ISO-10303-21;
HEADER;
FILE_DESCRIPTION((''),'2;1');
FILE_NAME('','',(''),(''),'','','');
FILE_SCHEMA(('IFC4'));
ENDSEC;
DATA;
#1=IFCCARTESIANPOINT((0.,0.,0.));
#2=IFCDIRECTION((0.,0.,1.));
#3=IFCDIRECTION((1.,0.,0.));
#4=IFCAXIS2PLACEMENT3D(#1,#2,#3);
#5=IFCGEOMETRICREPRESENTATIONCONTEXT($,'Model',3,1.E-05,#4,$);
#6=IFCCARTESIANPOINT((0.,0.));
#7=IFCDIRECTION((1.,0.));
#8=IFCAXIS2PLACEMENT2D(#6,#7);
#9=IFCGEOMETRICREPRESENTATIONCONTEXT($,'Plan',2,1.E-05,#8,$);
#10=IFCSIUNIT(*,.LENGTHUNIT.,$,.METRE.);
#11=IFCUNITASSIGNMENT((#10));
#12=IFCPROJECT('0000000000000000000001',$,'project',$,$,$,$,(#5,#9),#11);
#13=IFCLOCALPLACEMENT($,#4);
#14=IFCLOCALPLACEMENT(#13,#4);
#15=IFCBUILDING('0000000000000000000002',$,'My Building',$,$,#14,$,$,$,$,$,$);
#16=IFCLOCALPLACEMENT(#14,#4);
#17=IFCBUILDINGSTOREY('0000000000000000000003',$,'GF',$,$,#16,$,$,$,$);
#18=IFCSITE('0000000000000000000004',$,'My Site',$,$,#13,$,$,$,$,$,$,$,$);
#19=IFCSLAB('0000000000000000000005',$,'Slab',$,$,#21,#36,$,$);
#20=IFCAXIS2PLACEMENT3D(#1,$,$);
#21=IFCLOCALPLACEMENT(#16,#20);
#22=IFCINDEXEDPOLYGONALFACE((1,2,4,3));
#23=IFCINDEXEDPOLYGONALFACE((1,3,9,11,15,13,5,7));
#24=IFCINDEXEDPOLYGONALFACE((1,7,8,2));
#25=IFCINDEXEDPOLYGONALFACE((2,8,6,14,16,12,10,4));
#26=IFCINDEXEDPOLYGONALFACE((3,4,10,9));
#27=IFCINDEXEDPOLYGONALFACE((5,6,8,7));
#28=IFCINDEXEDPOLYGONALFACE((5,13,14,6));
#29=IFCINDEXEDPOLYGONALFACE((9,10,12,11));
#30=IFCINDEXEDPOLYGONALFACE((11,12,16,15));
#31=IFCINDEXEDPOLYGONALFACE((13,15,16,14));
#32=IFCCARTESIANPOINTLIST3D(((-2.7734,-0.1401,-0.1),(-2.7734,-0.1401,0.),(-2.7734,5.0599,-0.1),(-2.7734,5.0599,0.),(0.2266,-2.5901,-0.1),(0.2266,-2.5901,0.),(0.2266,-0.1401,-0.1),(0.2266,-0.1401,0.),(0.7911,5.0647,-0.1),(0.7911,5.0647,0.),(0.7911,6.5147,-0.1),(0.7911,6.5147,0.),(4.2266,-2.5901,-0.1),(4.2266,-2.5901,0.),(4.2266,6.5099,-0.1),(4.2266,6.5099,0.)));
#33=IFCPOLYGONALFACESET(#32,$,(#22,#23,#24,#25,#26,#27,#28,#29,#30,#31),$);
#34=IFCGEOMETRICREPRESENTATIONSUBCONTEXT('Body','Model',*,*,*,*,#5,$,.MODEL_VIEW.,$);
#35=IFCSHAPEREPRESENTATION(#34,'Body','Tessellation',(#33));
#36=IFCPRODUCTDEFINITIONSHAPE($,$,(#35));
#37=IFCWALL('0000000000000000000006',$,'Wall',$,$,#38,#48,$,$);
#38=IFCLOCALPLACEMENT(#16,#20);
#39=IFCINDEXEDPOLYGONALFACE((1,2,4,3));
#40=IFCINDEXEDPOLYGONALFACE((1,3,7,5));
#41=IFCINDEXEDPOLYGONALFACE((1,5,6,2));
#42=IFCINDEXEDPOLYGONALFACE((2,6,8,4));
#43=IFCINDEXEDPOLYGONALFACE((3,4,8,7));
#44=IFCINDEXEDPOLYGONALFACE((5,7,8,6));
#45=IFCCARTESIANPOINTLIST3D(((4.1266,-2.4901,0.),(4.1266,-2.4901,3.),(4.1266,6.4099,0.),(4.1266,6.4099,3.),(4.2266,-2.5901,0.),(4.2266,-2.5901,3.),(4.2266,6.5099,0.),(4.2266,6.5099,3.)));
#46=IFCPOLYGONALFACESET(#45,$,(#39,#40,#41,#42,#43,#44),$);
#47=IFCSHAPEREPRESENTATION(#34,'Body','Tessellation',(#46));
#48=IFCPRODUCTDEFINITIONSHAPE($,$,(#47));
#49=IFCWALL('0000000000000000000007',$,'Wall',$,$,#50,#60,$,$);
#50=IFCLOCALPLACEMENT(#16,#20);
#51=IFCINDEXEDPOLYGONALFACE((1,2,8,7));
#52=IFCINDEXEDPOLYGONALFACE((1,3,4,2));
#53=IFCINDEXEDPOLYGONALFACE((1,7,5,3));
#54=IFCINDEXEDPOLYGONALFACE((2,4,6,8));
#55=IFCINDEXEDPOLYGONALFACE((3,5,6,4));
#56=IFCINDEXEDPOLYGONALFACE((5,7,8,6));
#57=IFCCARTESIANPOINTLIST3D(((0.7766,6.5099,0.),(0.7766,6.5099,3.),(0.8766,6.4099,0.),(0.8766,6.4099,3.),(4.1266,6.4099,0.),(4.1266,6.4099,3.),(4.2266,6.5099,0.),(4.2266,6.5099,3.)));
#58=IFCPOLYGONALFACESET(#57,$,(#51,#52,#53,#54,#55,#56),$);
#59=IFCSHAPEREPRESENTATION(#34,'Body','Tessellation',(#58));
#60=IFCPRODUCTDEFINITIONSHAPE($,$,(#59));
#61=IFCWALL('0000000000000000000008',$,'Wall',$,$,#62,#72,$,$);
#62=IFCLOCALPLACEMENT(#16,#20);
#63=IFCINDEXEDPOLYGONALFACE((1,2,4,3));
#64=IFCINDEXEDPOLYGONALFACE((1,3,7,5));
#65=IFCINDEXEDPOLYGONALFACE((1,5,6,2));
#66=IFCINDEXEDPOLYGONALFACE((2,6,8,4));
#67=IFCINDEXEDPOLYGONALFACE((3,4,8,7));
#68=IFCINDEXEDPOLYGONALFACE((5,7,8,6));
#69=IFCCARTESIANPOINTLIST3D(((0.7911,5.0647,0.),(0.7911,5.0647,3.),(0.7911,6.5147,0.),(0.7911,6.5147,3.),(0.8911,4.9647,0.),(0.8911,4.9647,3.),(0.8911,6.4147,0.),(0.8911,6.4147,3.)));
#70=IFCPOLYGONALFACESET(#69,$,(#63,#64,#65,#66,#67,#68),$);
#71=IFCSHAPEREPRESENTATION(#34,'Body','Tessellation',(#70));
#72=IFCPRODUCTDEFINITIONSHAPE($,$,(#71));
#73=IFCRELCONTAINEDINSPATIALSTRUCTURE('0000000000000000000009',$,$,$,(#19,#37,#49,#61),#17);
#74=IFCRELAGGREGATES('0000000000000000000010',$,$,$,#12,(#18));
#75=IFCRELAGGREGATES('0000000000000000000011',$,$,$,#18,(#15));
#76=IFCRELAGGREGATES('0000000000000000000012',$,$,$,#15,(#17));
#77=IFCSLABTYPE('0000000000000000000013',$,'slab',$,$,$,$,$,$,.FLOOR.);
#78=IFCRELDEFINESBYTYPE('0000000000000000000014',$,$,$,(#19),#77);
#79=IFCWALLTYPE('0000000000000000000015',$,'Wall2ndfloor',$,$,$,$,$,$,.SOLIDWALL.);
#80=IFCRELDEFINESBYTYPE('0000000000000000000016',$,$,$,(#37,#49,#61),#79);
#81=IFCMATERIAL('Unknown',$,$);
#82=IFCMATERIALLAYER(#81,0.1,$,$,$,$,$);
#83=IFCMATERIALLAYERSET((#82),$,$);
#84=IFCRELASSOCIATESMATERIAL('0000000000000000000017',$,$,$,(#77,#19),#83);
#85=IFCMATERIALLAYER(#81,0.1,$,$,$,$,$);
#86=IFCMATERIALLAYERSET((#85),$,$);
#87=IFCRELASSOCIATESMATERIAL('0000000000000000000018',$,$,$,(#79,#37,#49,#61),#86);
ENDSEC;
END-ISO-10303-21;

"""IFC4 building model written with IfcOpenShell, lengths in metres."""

from ifc_helpers import new_model, si_unit, frame, origin_with_axes, origin_2d_with_axis, place, context, subcontext, project, spatial, line, indexed_curve, outline, extrude, material, layer, layer_set, layer_usage, type_object, element, save


model = new_model("IFC4")

# Units and contexts
model_context = context("Model", 3, precision=1e-05, world=origin_with_axes())
plan_context = context("Plan", 2, precision=1e-05, world=origin_2d_with_axis())
body_context_1 = subcontext(model_context, "Body", "Model", "MODEL_VIEW")
ifc_project = project(units=[si_unit("LENGTHUNIT", "METRE")], contexts=[model_context, plan_context])

# Site, building, storey
site_placement = place(None, origin_with_axes())
site = spatial("IfcSite", under=ifc_project, at=site_placement, Name="My Site")
building_placement = place(site_placement, origin_with_axes())
building = spatial("IfcBuilding", under=site, at=building_placement, Name="My Building")
storey_placement = place(building_placement, origin_with_axes())
storey = spatial("IfcBuildingStorey", under=building, at=storey_placement, Name="GF")

# Slab
ifc_material = material(Name="Unknown")
ifc_layer_1 = layer(ifc_material, 0.1)
ifc_layer_set_1 = layer_set([ifc_layer_1])
ifc_layer_usage_1 = layer_usage(ifc_layer_set_1, "AXIS3", "POSITIVE", -0.1)
slab_type = type_object("IfcSlabType", Name="slab", PredefinedType="FLOOR", material=ifc_layer_set_1)
slab_placement = place(storey_placement, frame((0.2266, -2.5901, 0.0), z_axis=(0.0, 0.0, 1.0), x_axis=(1.0, 0.0, 0.0)))
element("IfcSlab", 1, at=slab_placement, inside=storey, type_object=slab_type, material=ifc_layer_usage_1, Name="Slab", context=body_context_1, shape_type="SweptSolid", body=[
    extrude(outline(indexed_curve([(0.0, 0.0), (4.0, 0.0), (4.0, 9.1), (0.5645, 9.1048), (0.5645, 7.6548), (-3.0, 7.65), (-3.0, 2.45), (0.0, 2.45), (0.0, 0.0)])), frame((0.0, 0.0, -0.1), z_axis=(0.0, 0.0, 1.0), x_axis=(1.0, 0.0, 0.0)), (0.0, 0.0, 1.0), 0.1),
])

# Shared definitions
ifc_layer_2 = layer(ifc_material, 0.1)
ifc_layer_set_2 = layer_set([ifc_layer_2])
wall_type = type_object("IfcWallType", Name="Wall2ndfloor", PredefinedType="SOLIDWALL", material=ifc_layer_set_2)

# Walls
ifc_layer_usage_2 = layer_usage(ifc_layer_set_2, "AXIS2", "POSITIVE", 0.0)
wall_1_placement = place(storey_placement, frame((4.2266, -2.5901, 0.0), z_axis=(0.0, 0.0, 1.0), x_axis=(0.0, 1.0, 0.0)))
element("IfcWall", 2, at=wall_1_placement, inside=storey, type_object=wall_type, material=ifc_layer_usage_2, Name="Wall", context=body_context_1, shape_type="SweptSolid", body=[
    extrude(outline(indexed_curve([(0.0, 0.0), (0.1, 0.1), (9.0, 0.1), (9.1, 0.0)], segments=[line(1, 2, 3, 4, 1)])), origin_with_axes(), (0.0, 0.0, 1.0), 3.0),
])
ifc_layer_usage_3 = layer_usage(ifc_layer_set_2, "AXIS2", "POSITIVE", 0.0)
wall_2_placement = place(storey_placement, frame((4.2266, 6.5099, 0.0), z_axis=(0.0, 0.0, 1.0), x_axis=(-1.0, 0.0, 0.0)))
element("IfcWall", 3, at=wall_2_placement, inside=storey, type_object=wall_type, material=ifc_layer_usage_3, Name="Wall", context=body_context_1, shape_type="SweptSolid", body=[
    extrude(outline(indexed_curve([(0.0, 0.0), (0.1, 0.1), (3.35, 0.1), (3.45, 0.0)], segments=[line(1, 2, 3, 4, 1)])), origin_with_axes(), (0.0, 0.0, 1.0), 3.0),
])
ifc_layer_usage_4 = layer_usage(ifc_layer_set_2, "AXIS2", "POSITIVE", 0.0)
wall_3_placement = place(storey_placement, frame((0.7911, 6.5147, 0.0), z_axis=(0.0, 0.0, 1.0), x_axis=(0.0, -1.0, 0.0)))
element("IfcWall", 4, at=wall_3_placement, inside=storey, type_object=wall_type, material=ifc_layer_usage_4, Name="Wall", context=body_context_1, shape_type="SweptSolid", body=[
    extrude(outline(indexed_curve([(0.0, 0.0), (0.1, 0.1), (1.55, 0.1), (1.45, 0.0)], segments=[line(1, 2, 3, 4, 1)])), origin_with_axes(), (0.0, 0.0, 1.0), 3.0),
])

save(model, "model.ifc")
